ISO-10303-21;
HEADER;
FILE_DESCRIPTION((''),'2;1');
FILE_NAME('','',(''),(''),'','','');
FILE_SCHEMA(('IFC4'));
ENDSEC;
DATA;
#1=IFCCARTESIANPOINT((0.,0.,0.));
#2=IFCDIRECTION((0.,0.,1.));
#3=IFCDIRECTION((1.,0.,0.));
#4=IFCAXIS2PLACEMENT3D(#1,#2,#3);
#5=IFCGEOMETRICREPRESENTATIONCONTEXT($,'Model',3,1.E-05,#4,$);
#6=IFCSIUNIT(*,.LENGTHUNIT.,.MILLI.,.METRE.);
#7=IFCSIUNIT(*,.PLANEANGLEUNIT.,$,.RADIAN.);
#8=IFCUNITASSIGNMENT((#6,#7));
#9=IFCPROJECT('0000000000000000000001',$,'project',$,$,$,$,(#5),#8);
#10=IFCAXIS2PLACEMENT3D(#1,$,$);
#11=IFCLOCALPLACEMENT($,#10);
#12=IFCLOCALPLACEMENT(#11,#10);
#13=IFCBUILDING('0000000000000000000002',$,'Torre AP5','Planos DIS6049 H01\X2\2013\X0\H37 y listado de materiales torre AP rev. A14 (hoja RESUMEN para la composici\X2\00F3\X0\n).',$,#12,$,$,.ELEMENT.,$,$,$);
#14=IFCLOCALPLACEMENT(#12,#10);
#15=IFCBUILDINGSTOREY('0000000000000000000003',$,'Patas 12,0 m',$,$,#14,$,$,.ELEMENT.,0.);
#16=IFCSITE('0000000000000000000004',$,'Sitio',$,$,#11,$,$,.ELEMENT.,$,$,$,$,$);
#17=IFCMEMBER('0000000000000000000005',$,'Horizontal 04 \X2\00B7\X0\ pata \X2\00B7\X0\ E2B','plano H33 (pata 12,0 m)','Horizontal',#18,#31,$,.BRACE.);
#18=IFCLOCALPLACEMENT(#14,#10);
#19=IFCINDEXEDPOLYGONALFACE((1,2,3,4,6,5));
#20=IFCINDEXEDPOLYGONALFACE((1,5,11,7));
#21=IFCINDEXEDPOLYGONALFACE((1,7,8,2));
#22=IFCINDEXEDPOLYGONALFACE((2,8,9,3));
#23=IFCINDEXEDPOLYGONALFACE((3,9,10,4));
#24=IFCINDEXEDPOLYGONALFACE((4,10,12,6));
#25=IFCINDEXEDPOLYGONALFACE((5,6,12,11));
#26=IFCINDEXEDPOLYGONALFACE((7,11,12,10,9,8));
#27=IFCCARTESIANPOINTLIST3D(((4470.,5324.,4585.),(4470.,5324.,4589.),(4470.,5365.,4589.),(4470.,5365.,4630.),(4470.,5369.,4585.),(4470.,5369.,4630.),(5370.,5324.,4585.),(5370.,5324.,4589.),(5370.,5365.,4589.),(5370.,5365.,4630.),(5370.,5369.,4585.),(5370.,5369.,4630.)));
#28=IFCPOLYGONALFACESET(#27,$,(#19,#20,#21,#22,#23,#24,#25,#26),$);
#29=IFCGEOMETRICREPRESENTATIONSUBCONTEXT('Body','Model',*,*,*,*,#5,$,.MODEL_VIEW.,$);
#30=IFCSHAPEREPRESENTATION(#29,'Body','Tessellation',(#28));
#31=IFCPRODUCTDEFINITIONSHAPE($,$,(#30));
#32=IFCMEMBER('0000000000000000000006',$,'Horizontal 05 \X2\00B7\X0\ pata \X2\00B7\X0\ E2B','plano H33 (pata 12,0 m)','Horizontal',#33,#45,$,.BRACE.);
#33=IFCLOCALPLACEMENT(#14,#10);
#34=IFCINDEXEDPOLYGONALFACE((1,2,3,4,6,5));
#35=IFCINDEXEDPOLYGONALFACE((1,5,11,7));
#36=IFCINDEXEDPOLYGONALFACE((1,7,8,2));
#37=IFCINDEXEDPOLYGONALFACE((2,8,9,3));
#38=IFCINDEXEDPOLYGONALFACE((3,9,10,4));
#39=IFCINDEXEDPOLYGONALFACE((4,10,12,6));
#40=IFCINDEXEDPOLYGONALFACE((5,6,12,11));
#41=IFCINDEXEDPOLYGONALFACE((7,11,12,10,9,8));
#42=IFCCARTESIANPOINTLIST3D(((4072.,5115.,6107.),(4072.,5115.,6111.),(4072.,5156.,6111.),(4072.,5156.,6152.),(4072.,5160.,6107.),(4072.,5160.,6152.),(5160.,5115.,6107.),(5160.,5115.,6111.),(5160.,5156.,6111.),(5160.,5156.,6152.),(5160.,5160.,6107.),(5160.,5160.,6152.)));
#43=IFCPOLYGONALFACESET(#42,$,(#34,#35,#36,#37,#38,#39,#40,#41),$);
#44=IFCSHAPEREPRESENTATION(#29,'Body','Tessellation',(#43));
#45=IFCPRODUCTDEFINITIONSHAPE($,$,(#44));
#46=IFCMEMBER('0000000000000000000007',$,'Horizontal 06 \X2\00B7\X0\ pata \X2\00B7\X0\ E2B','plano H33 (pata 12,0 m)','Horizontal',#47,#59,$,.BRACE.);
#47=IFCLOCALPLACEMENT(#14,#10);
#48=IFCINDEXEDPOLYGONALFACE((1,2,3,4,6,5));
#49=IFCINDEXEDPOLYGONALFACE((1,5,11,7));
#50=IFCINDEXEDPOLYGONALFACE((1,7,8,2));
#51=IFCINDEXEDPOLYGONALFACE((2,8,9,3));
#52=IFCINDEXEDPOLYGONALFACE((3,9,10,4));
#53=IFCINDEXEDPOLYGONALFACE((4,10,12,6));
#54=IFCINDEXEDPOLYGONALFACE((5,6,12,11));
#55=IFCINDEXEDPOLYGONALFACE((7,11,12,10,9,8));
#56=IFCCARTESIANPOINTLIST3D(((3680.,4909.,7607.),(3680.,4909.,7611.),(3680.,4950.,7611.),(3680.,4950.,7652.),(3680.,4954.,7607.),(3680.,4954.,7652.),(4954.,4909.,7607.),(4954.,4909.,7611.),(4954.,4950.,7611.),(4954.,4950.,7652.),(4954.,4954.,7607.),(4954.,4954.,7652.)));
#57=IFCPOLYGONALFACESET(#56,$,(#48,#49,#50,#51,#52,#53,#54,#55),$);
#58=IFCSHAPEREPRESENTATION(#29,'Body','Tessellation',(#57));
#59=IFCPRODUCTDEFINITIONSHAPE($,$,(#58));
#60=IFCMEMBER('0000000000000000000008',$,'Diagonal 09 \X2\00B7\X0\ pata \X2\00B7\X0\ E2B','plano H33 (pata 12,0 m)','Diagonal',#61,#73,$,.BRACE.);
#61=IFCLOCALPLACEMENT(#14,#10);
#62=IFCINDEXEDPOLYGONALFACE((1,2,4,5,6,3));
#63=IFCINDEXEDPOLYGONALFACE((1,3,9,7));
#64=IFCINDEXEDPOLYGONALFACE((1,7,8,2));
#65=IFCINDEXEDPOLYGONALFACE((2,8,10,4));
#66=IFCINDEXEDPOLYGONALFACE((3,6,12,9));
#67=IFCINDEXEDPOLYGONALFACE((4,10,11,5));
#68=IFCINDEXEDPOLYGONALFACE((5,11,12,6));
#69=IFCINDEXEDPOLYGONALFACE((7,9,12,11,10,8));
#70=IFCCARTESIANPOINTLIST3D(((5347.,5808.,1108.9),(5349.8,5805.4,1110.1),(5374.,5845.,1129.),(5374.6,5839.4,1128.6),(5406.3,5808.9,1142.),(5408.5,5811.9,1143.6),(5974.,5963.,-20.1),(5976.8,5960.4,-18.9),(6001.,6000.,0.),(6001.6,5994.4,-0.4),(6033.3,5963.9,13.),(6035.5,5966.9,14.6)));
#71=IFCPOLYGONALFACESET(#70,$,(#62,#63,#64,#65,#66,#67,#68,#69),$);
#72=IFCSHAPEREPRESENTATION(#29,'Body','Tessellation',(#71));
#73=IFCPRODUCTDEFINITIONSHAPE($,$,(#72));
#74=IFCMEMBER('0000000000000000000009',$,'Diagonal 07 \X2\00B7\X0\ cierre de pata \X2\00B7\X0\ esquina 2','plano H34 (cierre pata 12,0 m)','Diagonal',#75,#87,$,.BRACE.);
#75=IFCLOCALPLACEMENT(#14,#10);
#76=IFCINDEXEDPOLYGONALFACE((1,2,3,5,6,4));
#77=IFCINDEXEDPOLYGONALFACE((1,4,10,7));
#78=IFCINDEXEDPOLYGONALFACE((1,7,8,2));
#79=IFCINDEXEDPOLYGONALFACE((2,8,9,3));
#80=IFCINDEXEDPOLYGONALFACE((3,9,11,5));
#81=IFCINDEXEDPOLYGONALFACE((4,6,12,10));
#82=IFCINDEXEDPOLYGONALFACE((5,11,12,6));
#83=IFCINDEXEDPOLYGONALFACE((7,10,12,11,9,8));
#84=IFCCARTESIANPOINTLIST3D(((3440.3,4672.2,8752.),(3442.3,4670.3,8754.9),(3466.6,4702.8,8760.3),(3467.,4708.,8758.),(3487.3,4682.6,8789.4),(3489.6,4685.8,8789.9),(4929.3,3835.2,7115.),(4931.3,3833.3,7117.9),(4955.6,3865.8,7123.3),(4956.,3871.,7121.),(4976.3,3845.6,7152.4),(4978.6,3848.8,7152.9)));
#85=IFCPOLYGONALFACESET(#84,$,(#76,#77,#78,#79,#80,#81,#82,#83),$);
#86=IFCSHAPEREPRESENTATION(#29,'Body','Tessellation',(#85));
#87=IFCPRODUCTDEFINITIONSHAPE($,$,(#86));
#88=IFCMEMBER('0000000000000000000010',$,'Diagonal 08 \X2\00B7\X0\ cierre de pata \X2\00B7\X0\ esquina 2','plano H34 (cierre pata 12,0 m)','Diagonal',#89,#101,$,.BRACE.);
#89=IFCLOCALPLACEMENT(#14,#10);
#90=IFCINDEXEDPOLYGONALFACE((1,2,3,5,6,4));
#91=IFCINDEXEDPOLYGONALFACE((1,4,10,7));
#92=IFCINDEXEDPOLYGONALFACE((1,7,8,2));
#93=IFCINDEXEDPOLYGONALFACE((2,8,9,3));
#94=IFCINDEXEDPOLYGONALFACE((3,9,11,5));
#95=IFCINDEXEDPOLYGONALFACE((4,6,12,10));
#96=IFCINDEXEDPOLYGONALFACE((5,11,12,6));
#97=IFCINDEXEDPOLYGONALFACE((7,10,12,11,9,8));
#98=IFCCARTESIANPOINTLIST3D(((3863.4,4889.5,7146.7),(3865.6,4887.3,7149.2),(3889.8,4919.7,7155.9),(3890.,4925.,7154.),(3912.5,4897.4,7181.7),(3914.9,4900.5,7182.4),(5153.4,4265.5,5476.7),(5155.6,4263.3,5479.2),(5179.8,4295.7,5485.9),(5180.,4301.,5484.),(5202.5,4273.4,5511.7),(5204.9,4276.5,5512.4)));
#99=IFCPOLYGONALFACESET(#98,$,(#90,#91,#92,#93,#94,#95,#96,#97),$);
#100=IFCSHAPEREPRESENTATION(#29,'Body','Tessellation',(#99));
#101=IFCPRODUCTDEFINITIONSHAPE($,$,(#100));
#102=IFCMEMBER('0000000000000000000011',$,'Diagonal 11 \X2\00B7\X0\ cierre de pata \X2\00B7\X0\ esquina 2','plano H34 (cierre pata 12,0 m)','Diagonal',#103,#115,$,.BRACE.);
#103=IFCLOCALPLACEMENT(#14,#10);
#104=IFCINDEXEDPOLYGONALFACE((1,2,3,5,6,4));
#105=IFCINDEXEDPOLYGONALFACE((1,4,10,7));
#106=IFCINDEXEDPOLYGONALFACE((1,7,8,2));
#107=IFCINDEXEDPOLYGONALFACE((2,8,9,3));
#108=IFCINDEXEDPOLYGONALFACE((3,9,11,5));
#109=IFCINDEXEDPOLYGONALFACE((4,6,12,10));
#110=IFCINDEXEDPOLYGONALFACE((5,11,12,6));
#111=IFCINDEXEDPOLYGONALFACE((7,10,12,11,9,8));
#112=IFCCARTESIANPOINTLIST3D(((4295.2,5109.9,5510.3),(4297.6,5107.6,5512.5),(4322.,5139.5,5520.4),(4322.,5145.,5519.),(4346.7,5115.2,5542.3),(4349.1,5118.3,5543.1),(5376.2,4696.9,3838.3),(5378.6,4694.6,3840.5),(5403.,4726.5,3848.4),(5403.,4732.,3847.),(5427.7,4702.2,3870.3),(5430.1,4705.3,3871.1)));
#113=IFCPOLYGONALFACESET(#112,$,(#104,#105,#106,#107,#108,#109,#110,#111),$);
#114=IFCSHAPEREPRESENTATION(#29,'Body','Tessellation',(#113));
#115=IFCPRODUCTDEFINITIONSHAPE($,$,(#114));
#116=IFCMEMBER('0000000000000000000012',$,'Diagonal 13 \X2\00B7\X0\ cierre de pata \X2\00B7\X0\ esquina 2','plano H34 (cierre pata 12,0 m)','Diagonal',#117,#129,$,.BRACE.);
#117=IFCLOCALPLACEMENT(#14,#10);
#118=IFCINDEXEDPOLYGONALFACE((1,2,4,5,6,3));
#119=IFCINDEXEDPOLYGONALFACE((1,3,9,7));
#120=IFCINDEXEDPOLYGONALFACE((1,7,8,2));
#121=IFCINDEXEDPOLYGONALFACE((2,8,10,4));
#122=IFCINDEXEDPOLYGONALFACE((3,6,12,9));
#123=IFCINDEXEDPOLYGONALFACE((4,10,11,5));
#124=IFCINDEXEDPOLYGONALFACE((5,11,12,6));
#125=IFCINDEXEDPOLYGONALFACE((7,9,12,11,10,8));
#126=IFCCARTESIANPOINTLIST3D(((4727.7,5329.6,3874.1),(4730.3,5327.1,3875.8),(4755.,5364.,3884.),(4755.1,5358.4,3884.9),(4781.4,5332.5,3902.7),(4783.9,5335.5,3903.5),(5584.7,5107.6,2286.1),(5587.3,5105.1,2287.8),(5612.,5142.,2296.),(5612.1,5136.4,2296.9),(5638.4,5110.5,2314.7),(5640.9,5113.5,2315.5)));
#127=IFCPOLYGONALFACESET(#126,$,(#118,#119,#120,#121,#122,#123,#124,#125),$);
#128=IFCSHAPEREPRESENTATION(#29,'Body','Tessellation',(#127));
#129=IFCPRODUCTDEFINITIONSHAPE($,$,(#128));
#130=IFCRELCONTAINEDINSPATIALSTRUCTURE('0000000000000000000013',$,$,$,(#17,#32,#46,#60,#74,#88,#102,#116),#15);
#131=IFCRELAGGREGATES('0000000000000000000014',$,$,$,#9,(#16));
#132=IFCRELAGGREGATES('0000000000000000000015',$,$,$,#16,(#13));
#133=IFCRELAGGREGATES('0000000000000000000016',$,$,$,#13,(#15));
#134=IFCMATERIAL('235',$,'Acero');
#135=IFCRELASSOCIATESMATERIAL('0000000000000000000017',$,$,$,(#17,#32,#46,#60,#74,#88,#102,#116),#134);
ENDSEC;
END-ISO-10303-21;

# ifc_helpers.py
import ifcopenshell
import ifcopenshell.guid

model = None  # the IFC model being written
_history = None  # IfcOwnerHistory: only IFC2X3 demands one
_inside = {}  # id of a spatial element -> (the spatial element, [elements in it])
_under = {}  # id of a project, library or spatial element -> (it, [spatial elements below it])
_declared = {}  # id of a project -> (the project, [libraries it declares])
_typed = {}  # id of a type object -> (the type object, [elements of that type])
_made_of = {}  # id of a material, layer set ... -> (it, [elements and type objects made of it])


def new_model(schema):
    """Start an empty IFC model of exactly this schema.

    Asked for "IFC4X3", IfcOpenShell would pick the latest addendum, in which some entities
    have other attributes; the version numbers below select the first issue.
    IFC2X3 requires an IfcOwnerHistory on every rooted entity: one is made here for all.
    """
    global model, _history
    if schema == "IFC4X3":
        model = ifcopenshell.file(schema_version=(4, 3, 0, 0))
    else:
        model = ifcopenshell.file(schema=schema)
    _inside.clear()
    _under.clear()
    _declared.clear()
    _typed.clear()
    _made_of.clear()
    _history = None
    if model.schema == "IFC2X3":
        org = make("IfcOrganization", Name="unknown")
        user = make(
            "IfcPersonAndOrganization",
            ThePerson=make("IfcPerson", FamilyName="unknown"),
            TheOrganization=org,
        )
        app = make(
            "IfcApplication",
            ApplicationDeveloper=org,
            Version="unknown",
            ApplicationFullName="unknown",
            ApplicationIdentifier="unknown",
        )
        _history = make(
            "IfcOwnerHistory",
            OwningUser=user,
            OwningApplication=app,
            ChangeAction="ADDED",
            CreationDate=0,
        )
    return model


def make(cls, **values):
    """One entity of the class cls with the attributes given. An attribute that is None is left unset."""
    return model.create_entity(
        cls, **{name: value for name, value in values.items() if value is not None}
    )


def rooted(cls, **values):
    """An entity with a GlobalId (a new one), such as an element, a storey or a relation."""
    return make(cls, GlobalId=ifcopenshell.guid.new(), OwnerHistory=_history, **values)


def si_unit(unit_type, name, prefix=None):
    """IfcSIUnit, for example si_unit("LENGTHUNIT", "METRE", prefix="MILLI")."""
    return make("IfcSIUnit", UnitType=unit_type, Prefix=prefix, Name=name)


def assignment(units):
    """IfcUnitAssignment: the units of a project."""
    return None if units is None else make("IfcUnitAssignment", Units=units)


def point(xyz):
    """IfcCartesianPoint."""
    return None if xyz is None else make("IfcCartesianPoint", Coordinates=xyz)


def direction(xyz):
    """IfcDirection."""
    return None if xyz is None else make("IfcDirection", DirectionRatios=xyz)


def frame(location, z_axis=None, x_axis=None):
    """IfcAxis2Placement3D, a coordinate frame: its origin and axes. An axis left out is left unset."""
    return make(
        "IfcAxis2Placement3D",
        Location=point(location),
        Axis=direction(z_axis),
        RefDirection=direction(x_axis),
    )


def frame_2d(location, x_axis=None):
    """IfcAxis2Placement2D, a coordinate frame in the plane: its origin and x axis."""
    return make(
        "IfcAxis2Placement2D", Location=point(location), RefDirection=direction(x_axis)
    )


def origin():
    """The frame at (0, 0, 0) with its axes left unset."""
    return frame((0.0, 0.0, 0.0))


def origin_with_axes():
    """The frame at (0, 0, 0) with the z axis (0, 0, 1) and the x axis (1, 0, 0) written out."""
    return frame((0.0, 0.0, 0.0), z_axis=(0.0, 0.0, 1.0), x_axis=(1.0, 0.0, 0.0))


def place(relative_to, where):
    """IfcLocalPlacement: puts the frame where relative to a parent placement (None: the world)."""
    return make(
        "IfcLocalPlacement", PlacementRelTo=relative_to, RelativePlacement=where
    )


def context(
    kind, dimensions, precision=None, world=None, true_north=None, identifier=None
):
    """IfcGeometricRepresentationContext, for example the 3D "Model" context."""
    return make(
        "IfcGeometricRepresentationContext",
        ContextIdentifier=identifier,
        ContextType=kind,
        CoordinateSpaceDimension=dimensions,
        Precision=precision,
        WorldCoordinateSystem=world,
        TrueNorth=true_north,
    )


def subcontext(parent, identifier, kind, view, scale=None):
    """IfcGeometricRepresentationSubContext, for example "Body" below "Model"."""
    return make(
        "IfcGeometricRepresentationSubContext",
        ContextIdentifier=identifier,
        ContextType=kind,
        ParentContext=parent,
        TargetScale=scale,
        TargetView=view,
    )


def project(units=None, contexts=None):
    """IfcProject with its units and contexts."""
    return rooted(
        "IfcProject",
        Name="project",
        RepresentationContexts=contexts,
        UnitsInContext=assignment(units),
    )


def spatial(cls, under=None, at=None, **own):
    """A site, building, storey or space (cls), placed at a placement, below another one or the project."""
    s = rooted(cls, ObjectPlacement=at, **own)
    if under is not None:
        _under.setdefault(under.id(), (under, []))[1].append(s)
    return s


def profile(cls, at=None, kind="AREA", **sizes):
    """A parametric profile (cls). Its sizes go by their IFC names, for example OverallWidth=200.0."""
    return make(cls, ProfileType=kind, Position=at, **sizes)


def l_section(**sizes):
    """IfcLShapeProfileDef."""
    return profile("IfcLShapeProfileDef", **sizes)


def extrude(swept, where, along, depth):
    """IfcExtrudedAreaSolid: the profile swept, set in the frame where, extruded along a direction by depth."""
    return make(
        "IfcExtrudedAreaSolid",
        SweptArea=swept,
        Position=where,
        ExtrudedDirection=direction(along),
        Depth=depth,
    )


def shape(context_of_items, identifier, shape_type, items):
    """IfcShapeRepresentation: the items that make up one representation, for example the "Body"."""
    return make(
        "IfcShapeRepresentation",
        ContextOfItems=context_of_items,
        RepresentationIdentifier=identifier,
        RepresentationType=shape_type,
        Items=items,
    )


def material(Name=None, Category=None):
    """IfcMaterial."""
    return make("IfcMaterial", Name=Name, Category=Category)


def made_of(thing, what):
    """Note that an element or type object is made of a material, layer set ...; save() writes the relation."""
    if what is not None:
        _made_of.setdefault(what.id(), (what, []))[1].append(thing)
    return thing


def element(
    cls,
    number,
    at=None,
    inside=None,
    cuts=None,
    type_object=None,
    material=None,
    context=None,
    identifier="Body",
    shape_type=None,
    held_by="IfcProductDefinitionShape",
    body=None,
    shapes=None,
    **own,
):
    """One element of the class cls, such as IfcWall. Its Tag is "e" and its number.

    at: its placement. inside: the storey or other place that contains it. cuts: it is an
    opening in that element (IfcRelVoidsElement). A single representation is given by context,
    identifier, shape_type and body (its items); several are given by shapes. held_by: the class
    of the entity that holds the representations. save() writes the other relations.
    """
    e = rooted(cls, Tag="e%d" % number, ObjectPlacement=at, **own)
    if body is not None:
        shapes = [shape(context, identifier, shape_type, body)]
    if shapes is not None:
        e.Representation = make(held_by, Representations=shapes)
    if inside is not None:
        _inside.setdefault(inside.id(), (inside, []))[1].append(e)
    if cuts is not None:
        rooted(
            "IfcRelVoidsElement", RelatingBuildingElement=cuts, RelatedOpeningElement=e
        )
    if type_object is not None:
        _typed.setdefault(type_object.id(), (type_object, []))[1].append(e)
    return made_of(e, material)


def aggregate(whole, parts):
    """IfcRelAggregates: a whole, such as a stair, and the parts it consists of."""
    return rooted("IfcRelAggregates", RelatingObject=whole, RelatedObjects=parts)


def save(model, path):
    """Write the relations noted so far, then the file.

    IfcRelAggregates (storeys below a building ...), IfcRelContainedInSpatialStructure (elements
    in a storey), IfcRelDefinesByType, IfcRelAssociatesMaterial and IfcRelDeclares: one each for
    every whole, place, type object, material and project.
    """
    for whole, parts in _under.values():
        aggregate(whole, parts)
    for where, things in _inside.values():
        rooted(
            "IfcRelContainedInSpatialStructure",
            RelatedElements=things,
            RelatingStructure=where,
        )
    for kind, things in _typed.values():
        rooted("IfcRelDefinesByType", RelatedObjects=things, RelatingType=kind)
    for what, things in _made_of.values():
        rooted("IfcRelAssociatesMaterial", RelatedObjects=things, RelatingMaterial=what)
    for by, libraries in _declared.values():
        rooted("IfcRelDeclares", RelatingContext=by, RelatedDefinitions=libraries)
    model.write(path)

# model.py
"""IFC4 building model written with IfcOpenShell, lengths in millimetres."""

from ifc_helpers import new_model, si_unit, frame, frame_2d, origin, origin_with_axes, place, context, subcontext, project, spatial, l_section, extrude, material, element, save


model = new_model("IFC4")

# Units and contexts
model_context = context("Model", 3, precision=1e-05, world=origin_with_axes())
body_context = subcontext(model_context, "Body", "Model", "MODEL_VIEW")
ifc_project = project(units=[si_unit("LENGTHUNIT", "METRE", prefix="MILLI"), si_unit("PLANEANGLEUNIT", "RADIAN")], contexts=[model_context])

# Site, building, storey
site_placement = place(None, origin())
site = spatial("IfcSite", under=ifc_project, at=site_placement, Name="Sitio", CompositionType="ELEMENT")
building_placement = place(site_placement, origin())
building = spatial("IfcBuilding", under=site, at=building_placement, Name="Torre AP5", Description="Planos DIS6049 H01–H37 y listado de materiales torre AP rev. A14 (hoja RESUMEN para la composición).", CompositionType="ELEMENT")
storey_placement = place(building_placement, origin())
storey = spatial("IfcBuildingStorey", under=building, at=storey_placement, Name="Patas 12,0 m", CompositionType="ELEMENT", Elevation=0.0)

# Members
ifc_material_1 = material(Name="235", Category="Acero")
member_1_placement = place(storey_placement, frame((5370.0, 5369.0, 4585.0), z_axis=(-1.0, 0.0, 0.0), x_axis=(0.0, -1.0, 0.0)))
element("IfcMember", 1, at=member_1_placement, inside=storey, material=ifc_material_1, Name="Horizontal 04 · pata · E2B", Description="plano H33 (pata 12,0 m)", ObjectType="Horizontal", PredefinedType="BRACE", context=body_context, shape_type="SweptSolid", body=[
    extrude(l_section(Depth=45.0, Width=45.0, Thickness=4.0, at=frame_2d((22.5, 22.5))), None, (0.0, 0.0, 1.0), 900.0),
])
member_2_placement = place(storey_placement, frame((5160.0, 5160.0, 6107.0), z_axis=(-1.0, 0.0, 0.0), x_axis=(0.0, -1.0, 0.0)))
element("IfcMember", 2, at=member_2_placement, inside=storey, material=ifc_material_1, Name="Horizontal 05 · pata · E2B", Description="plano H33 (pata 12,0 m)", ObjectType="Horizontal", PredefinedType="BRACE", context=body_context, shape_type="SweptSolid", body=[
    extrude(l_section(Depth=45.0, Width=45.0, Thickness=4.0, at=frame_2d((22.5, 22.5))), None, (0.0, 0.0, 1.0), 1088.0),
])
member_3_placement = place(storey_placement, frame((4954.0, 4954.0, 7607.0), z_axis=(-1.0, 0.0, 0.0), x_axis=(0.0, -1.0, 0.0)))
element("IfcMember", 3, at=member_3_placement, inside=storey, material=ifc_material_1, Name="Horizontal 06 · pata · E2B", Description="plano H33 (pata 12,0 m)", ObjectType="Horizontal", PredefinedType="BRACE", context=body_context, shape_type="SweptSolid", body=[
    extrude(l_section(Depth=45.0, Width=45.0, Thickness=4.0, at=frame_2d((22.5, 22.5))), None, (0.0, 0.0, 1.0), 1274.0),
])
member_4_placement = place(storey_placement, frame((6001.0, 6000.0, 0.0), z_axis=(-0.482052, -0.119168, 0.868001), x_axis=(-0.54018, -0.73958, -0.40153)))
element("IfcMember", 4, at=member_4_placement, inside=storey, material=ifc_material_1, Name="Diagonal 09 · pata · E2B", Description="plano H33 (pata 12,0 m)", ObjectType="Diagonal", PredefinedType="BRACE", context=body_context, shape_type="SweptSolid", body=[
    extrude(l_section(Depth=50.0, Width=50.0, Thickness=4.0, at=frame_2d((25.0, 25.0))), None, (0.0, 0.0, 1.0), 1300.7),
])
member_5_placement = place(storey_placement, frame((4956.0, 3871.0, 7121.0), z_axis=(-0.62936, 0.353777, 0.691916), x_axis=(-0.592588, -0.794484, -0.132792)))
element("IfcMember", 5, at=member_5_placement, inside=storey, material=ifc_material_1, Name="Diagonal 07 · cierre de pata · esquina 2", Description="plano H34 (cierre pata 12,0 m)", ObjectType="Diagonal", PredefinedType="BRACE", context=body_context, shape_type="SweptSolid", body=[
    extrude(l_section(Depth=45.0, Width=45.0, Thickness=4.0, at=frame_2d((22.5, 22.5))), None, (0.0, 0.0, 1.0), 2365.9),
])
member_6_placement = place(storey_placement, frame((5180.0, 4301.0, 5484.0), z_axis=(-0.58622, 0.283567, 0.758905), x_axis=(-0.591712, -0.789705, -0.161995)))
element("IfcMember", 6, at=member_6_placement, inside=storey, material=ifc_material_1, Name="Diagonal 08 · cierre de pata · esquina 2", Description="plano H34 (cierre pata 12,0 m)", ObjectType="Diagonal", PredefinedType="BRACE", context=body_context, shape_type="SweptSolid", body=[
    extrude(l_section(Depth=45.0, Width=45.0, Thickness=4.0, at=frame_2d((22.5, 22.5))), None, (0.0, 0.0, 1.0), 2200.5),
])
member_7_placement = place(storey_placement, frame((5403.0, 4732.0, 3847.0), z_axis=(-0.531622, 0.203108, 0.822268), x_axis=(-0.595989, -0.779508, -0.192779)))
element("IfcMember", 7, at=member_7_placement, inside=storey, material=ifc_material_1, Name="Diagonal 11 · cierre de pata · esquina 2", Description="plano H34 (cierre pata 12,0 m)", ObjectType="Diagonal", PredefinedType="BRACE", context=body_context, shape_type="SweptSolid", body=[
    extrude(l_section(Depth=45.0, Width=45.0, Thickness=4.0, at=frame_2d((22.5, 22.5))), None, (0.0, 0.0, 1.0), 2033.4),
])
member_8_placement = place(storey_placement, frame((5612.0, 5142.0, 2296.0), z_axis=(-0.471372, 0.122106, 0.873441), x_axis=(-0.605619, -0.764761, -0.219923)))
element("IfcMember", 8, at=member_8_placement, inside=storey, material=ifc_material_1, Name="Diagonal 13 · cierre de pata · esquina 2", Description="plano H34 (cierre pata 12,0 m)", ObjectType="Diagonal", PredefinedType="BRACE", context=body_context, shape_type="SweptSolid", body=[
    extrude(l_section(Depth=45.0, Width=45.0, Thickness=4.0, at=frame_2d((22.5, 22.5))), None, (0.0, 0.0, 1.0), 1818.1),
])

save(model, "model.ifc")
